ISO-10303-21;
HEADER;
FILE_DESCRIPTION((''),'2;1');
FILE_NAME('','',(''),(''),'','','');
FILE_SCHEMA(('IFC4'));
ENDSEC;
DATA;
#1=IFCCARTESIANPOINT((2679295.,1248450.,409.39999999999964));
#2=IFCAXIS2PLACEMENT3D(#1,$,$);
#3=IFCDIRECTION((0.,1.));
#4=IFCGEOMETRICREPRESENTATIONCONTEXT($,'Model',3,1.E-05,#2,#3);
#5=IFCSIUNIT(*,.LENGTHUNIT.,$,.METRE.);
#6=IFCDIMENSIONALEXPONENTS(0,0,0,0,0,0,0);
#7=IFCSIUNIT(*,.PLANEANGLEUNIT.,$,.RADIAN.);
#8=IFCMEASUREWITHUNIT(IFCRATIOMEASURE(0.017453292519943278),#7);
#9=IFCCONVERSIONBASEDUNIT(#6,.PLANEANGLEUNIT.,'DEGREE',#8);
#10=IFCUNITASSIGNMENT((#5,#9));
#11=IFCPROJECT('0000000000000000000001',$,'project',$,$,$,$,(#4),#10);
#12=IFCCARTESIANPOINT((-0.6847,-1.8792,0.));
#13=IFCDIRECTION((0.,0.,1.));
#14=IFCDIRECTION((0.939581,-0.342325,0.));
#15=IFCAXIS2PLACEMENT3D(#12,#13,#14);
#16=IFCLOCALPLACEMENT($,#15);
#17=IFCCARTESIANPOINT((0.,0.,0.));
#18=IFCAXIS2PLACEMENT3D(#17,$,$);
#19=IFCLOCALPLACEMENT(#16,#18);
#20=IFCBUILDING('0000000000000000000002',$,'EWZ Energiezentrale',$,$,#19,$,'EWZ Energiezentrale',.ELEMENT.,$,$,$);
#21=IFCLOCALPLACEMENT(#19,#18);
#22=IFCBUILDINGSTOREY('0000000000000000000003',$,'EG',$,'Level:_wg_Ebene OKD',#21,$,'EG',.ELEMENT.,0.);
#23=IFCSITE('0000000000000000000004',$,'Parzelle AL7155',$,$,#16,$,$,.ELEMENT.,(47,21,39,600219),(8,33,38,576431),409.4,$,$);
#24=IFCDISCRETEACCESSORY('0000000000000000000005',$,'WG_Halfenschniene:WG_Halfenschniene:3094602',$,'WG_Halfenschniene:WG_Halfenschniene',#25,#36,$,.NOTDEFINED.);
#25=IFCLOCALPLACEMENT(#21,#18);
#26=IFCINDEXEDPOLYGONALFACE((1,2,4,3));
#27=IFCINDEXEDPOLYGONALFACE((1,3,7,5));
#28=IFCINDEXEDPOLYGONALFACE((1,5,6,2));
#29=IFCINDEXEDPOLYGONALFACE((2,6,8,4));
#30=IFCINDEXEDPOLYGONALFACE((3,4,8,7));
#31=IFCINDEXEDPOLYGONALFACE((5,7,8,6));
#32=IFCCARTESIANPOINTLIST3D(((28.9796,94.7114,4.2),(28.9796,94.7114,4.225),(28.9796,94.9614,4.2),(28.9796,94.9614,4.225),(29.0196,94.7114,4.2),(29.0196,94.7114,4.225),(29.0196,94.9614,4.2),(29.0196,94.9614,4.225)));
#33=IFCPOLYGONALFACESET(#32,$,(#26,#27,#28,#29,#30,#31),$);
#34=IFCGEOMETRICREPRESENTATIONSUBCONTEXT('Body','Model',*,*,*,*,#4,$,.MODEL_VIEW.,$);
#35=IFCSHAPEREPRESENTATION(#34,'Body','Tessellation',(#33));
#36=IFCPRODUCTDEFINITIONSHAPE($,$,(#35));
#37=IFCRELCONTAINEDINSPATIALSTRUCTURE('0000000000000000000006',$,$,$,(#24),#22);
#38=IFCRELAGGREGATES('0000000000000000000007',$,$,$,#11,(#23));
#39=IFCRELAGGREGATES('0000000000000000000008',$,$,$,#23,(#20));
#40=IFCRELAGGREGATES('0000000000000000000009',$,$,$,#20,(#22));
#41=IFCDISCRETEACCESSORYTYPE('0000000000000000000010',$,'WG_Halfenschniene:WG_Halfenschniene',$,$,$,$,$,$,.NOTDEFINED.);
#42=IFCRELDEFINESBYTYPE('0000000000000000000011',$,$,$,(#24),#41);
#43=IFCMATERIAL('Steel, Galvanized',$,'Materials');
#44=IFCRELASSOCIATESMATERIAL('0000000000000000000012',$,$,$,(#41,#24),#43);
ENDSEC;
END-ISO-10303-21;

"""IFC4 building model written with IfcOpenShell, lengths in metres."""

from ifc_helpers import new_model, entity, si_unit, converted_unit, direction, frame, origin, place, context, subcontext, project, spatial, indexed_curve, outline, extrude, source, transform, mapped, material, type_object, element, save


model = new_model("IFC4")

# Units and contexts
model_context = context("Model", 3, precision=1e-05, world=frame((2679295.0, 1248450.0, 409.39999999999964)), true_north=direction((0.0, 1.0)))
body_context = subcontext(model_context, "Body", "Model", "MODEL_VIEW")
ifc_project = project(units=[si_unit("LENGTHUNIT", "METRE"), converted_unit("PLANEANGLEUNIT", "DEGREE", entity("IfcRatioMeasure", 0.017453292519943278), si_unit("PLANEANGLEUNIT", "RADIAN"), dimensions=[0, 0, 0, 0, 0, 0, 0])], contexts=[model_context])

# Site, building, storey
site_placement = place(None, frame((-0.6847, -1.8792, 0.0), z_axis=(0.0, 0.0, 1.0), x_axis=(0.939581, -0.342325, 0.0)))
site = spatial("IfcSite", under=ifc_project, at=site_placement, Name="Parzelle AL7155", CompositionType="ELEMENT", RefLatitude=(47, 21, 39, 600219), RefLongitude=(8, 33, 38, 576431), RefElevation=409.4)
building_placement = place(site_placement, origin())
building = spatial("IfcBuilding", under=site, at=building_placement, Name="EWZ Energiezentrale", LongName="EWZ Energiezentrale", CompositionType="ELEMENT")
storey_placement = place(building_placement, origin())
storey = spatial("IfcBuildingStorey", under=building, at=storey_placement, Name="EG", ObjectType="Level:_wg_Ebene OKD", LongName="EG", CompositionType="ELEMENT", Elevation=0.0)

# Discrete accessory
ifc_material = material(Name="Steel, Galvanized", Category="Materials")
discrete_accessory_type = type_object("IfcDiscreteAccessoryType", Name="WG_Halfenschniene:WG_Halfenschniene", PredefinedType="NOTDEFINED", material=ifc_material)
shared_shape = source(origin(), body_context, "Body", "SweptSolid", [
    extrude(outline(indexed_curve([(-0.125, -0.02), (0.125, -0.02), (0.125, 0.02), (-0.125, 0.02), (-0.125, -0.02)], self_intersect=False)), frame((0.125, 0.0, -0.0125)), (0.0, 0.0, 1.0), 0.025),
])
for number, where, z_axis, x_axis, name in (
    (1, (28.9996, 94.7114, 4.2125), (0.0, 0.0, -1.0), (0.0, 1.0, 0.0), "WG_Halfenschniene:WG_Halfenschniene:3094602"),
):
    element("IfcDiscreteAccessory", number, at=place(storey_placement, frame(where, z_axis=z_axis, x_axis=x_axis)), inside=storey, type_object=discrete_accessory_type, material=ifc_material, Name=name, ObjectType="WG_Halfenschniene:WG_Halfenschniene", PredefinedType="NOTDEFINED", context=body_context, shape_type="MappedRepresentation", body=[
        mapped(shared_shape, transform((0.0, 0.0, 0.0), scale=1.0)),
    ])

save(model, "model.ifc")
